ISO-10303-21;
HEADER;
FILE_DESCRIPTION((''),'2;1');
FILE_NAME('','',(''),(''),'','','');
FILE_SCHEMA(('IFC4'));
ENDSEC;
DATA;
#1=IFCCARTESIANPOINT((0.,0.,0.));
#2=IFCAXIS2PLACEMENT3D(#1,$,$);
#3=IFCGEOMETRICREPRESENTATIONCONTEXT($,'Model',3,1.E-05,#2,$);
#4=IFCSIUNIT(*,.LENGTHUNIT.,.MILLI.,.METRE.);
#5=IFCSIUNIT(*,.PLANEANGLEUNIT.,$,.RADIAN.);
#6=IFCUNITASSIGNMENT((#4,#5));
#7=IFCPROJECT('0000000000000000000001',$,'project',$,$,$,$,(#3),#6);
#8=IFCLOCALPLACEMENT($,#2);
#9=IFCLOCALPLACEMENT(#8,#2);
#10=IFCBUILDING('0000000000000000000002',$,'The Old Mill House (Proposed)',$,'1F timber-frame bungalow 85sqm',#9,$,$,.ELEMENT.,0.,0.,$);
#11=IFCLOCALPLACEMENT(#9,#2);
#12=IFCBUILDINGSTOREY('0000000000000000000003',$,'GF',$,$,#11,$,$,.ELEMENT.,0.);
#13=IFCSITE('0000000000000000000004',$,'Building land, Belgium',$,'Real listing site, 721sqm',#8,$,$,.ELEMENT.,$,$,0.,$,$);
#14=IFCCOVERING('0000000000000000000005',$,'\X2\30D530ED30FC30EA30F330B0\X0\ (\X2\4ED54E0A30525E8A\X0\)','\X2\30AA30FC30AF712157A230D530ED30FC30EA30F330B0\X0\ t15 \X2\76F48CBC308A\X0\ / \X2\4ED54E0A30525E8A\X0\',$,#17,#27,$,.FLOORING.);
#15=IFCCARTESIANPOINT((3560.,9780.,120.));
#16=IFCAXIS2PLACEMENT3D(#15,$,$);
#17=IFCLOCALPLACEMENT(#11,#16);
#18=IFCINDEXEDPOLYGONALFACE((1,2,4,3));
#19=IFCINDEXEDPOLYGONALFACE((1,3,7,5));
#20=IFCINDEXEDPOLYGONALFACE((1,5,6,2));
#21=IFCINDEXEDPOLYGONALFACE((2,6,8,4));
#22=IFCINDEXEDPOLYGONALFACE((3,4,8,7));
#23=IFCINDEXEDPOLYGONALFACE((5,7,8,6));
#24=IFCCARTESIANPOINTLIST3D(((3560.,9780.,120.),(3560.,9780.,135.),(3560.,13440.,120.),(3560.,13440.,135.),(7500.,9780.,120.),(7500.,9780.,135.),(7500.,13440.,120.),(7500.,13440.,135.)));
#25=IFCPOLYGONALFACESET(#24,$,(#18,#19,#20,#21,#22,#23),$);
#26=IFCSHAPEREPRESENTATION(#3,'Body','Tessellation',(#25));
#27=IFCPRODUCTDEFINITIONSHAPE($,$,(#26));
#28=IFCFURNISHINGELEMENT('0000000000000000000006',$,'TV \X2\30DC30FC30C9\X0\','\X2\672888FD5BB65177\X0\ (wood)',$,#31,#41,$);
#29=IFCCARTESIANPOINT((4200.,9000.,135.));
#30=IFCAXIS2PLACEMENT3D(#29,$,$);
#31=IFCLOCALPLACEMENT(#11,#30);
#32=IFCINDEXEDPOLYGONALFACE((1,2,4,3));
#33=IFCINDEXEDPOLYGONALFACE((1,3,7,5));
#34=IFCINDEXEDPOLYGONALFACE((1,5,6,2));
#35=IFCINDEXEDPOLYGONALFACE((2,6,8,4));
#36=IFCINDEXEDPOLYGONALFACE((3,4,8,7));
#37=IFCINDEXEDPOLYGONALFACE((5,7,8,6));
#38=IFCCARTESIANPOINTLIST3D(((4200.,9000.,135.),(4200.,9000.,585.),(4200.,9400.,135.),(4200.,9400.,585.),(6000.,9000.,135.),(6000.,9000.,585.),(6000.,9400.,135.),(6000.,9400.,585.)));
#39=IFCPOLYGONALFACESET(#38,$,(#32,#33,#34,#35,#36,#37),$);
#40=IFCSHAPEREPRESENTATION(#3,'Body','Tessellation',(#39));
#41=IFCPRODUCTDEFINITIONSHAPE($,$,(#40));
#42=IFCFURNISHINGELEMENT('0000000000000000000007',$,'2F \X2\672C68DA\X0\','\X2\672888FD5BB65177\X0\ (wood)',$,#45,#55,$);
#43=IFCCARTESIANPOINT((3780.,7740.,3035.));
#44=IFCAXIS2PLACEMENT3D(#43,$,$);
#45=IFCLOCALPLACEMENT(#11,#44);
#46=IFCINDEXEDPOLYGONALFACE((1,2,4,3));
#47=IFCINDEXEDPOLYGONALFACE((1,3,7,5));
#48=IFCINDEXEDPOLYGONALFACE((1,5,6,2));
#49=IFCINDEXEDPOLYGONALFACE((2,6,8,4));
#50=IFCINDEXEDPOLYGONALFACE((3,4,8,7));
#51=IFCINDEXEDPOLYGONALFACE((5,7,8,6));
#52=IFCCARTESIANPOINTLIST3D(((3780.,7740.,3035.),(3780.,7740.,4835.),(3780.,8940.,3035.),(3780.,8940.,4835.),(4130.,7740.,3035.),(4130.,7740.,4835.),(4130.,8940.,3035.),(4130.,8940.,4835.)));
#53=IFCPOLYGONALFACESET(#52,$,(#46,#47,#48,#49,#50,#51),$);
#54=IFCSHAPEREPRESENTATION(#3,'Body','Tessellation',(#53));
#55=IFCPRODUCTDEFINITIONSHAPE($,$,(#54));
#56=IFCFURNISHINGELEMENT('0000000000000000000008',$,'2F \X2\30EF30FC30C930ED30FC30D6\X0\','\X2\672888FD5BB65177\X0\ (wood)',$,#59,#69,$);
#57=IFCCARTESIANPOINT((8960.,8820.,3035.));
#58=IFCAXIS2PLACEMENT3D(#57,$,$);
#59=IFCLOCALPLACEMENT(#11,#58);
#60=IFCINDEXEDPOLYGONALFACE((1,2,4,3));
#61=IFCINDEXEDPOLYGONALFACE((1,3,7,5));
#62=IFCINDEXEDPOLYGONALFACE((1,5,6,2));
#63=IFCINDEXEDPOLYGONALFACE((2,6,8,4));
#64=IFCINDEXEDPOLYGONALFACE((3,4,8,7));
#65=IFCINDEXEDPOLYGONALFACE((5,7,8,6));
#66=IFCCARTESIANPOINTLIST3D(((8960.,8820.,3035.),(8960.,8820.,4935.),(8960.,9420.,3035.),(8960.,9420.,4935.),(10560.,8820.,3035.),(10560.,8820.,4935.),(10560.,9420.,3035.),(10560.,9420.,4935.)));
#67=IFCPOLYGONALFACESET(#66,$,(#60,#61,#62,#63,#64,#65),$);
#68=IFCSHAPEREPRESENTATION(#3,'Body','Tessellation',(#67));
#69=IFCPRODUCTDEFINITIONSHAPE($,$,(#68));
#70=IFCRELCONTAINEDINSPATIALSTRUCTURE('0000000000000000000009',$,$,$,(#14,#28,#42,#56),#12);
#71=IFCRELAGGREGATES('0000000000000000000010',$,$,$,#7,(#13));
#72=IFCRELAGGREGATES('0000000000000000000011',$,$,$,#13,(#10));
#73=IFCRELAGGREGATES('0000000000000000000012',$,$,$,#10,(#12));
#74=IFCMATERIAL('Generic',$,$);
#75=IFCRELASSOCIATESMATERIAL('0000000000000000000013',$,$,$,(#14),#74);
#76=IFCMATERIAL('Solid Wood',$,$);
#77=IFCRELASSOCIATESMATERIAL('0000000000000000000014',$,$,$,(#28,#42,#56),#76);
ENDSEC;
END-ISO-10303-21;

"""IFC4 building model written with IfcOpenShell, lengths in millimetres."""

from ifc_helpers import new_model, si_unit, frame, frame_2d, origin, place, context, project, spatial, rectangle, extrude, material, element, save


model = new_model("IFC4")

# Units and contexts
model_context = context("Model", 3, precision=1e-05, world=origin())
ifc_project = project(units=[si_unit("LENGTHUNIT", "METRE", prefix="MILLI"), si_unit("PLANEANGLEUNIT", "RADIAN")], contexts=[model_context])

# Site, building, storey
site_placement = place(None, origin())
site = spatial("IfcSite", under=ifc_project, at=site_placement, Name="Building land, Belgium", ObjectType="Real listing site, 721sqm", CompositionType="ELEMENT", RefElevation=0.0)
building_placement = place(site_placement, origin())
building = spatial("IfcBuilding", under=site, at=building_placement, Name="The Old Mill House (Proposed)", ObjectType="1F timber-frame bungalow 85sqm", CompositionType="ELEMENT", ElevationOfRefHeight=0.0, ElevationOfTerrain=0.0)
storey_placement = place(building_placement, origin())
storey = spatial("IfcBuildingStorey", under=building, at=storey_placement, Name="GF", CompositionType="ELEMENT", Elevation=0.0)

# Shared definitions
ifc_material_1 = material(Name="Solid Wood")

# Shared definitions
ifc_material_2 = material(Name="Generic")

# Covering
covering_placement = place(storey_placement, frame((3560.0, 9780.0, 120.0)))
element("IfcCovering", 1, at=covering_placement, inside=storey, material=ifc_material_2, Name="フローリング (仕上げ床)", Description="オーク無垢フローリング t15 直貼り / 仕上げ床", PredefinedType="FLOORING", context=model_context, shape_type="SweptSolid", body=[
    extrude(rectangle(XDim=3940.0, YDim=3660.0, at=frame_2d((1970.0, 1830.0))), frame((3560.0, 9780.0, 120.0)), (0.0, 0.0, 1.0), 15.0),
])

# Furnishing elements
furnishing_1_placement = place(storey_placement, frame((4200.0, 9000.0, 135.0)))
element("IfcFurnishingElement", 2, at=furnishing_1_placement, inside=storey, material=ifc_material_1, Name="TV ボード", Description="木製家具 (wood)", context=model_context, shape_type="SweptSolid", body=[
    extrude(rectangle(XDim=1800.0, YDim=400.0, at=frame_2d((900.0, 200.0))), frame((4200.0, 9000.0, 135.0)), (0.0, 0.0, 1.0), 450.0),
])
furnishing_2_placement = place(storey_placement, frame((3780.0, 7740.0, 3035.0)))
element("IfcFurnishingElement", 3, at=furnishing_2_placement, inside=storey, material=ifc_material_1, Name="2F 本棚", Description="木製家具 (wood)", context=model_context, shape_type="SweptSolid", body=[
    extrude(rectangle(XDim=350.0, YDim=1200.0, at=frame_2d((175.0, 600.0))), frame((3780.0, 7740.0, 3035.0)), (0.0, 0.0, 1.0), 1800.0),
])
furnishing_3_placement = place(storey_placement, frame((8960.0, 8820.0, 3035.0)))
element("IfcFurnishingElement", 4, at=furnishing_3_placement, inside=storey, material=ifc_material_1, Name="2F ワードローブ", Description="木製家具 (wood)", context=model_context, shape_type="SweptSolid", body=[
    extrude(rectangle(XDim=1600.0, YDim=600.0, at=frame_2d((800.0, 300.0))), frame((8960.0, 8820.0, 3035.0)), (0.0, 0.0, 1.0), 1900.0),
])

save(model, "model.ifc")
